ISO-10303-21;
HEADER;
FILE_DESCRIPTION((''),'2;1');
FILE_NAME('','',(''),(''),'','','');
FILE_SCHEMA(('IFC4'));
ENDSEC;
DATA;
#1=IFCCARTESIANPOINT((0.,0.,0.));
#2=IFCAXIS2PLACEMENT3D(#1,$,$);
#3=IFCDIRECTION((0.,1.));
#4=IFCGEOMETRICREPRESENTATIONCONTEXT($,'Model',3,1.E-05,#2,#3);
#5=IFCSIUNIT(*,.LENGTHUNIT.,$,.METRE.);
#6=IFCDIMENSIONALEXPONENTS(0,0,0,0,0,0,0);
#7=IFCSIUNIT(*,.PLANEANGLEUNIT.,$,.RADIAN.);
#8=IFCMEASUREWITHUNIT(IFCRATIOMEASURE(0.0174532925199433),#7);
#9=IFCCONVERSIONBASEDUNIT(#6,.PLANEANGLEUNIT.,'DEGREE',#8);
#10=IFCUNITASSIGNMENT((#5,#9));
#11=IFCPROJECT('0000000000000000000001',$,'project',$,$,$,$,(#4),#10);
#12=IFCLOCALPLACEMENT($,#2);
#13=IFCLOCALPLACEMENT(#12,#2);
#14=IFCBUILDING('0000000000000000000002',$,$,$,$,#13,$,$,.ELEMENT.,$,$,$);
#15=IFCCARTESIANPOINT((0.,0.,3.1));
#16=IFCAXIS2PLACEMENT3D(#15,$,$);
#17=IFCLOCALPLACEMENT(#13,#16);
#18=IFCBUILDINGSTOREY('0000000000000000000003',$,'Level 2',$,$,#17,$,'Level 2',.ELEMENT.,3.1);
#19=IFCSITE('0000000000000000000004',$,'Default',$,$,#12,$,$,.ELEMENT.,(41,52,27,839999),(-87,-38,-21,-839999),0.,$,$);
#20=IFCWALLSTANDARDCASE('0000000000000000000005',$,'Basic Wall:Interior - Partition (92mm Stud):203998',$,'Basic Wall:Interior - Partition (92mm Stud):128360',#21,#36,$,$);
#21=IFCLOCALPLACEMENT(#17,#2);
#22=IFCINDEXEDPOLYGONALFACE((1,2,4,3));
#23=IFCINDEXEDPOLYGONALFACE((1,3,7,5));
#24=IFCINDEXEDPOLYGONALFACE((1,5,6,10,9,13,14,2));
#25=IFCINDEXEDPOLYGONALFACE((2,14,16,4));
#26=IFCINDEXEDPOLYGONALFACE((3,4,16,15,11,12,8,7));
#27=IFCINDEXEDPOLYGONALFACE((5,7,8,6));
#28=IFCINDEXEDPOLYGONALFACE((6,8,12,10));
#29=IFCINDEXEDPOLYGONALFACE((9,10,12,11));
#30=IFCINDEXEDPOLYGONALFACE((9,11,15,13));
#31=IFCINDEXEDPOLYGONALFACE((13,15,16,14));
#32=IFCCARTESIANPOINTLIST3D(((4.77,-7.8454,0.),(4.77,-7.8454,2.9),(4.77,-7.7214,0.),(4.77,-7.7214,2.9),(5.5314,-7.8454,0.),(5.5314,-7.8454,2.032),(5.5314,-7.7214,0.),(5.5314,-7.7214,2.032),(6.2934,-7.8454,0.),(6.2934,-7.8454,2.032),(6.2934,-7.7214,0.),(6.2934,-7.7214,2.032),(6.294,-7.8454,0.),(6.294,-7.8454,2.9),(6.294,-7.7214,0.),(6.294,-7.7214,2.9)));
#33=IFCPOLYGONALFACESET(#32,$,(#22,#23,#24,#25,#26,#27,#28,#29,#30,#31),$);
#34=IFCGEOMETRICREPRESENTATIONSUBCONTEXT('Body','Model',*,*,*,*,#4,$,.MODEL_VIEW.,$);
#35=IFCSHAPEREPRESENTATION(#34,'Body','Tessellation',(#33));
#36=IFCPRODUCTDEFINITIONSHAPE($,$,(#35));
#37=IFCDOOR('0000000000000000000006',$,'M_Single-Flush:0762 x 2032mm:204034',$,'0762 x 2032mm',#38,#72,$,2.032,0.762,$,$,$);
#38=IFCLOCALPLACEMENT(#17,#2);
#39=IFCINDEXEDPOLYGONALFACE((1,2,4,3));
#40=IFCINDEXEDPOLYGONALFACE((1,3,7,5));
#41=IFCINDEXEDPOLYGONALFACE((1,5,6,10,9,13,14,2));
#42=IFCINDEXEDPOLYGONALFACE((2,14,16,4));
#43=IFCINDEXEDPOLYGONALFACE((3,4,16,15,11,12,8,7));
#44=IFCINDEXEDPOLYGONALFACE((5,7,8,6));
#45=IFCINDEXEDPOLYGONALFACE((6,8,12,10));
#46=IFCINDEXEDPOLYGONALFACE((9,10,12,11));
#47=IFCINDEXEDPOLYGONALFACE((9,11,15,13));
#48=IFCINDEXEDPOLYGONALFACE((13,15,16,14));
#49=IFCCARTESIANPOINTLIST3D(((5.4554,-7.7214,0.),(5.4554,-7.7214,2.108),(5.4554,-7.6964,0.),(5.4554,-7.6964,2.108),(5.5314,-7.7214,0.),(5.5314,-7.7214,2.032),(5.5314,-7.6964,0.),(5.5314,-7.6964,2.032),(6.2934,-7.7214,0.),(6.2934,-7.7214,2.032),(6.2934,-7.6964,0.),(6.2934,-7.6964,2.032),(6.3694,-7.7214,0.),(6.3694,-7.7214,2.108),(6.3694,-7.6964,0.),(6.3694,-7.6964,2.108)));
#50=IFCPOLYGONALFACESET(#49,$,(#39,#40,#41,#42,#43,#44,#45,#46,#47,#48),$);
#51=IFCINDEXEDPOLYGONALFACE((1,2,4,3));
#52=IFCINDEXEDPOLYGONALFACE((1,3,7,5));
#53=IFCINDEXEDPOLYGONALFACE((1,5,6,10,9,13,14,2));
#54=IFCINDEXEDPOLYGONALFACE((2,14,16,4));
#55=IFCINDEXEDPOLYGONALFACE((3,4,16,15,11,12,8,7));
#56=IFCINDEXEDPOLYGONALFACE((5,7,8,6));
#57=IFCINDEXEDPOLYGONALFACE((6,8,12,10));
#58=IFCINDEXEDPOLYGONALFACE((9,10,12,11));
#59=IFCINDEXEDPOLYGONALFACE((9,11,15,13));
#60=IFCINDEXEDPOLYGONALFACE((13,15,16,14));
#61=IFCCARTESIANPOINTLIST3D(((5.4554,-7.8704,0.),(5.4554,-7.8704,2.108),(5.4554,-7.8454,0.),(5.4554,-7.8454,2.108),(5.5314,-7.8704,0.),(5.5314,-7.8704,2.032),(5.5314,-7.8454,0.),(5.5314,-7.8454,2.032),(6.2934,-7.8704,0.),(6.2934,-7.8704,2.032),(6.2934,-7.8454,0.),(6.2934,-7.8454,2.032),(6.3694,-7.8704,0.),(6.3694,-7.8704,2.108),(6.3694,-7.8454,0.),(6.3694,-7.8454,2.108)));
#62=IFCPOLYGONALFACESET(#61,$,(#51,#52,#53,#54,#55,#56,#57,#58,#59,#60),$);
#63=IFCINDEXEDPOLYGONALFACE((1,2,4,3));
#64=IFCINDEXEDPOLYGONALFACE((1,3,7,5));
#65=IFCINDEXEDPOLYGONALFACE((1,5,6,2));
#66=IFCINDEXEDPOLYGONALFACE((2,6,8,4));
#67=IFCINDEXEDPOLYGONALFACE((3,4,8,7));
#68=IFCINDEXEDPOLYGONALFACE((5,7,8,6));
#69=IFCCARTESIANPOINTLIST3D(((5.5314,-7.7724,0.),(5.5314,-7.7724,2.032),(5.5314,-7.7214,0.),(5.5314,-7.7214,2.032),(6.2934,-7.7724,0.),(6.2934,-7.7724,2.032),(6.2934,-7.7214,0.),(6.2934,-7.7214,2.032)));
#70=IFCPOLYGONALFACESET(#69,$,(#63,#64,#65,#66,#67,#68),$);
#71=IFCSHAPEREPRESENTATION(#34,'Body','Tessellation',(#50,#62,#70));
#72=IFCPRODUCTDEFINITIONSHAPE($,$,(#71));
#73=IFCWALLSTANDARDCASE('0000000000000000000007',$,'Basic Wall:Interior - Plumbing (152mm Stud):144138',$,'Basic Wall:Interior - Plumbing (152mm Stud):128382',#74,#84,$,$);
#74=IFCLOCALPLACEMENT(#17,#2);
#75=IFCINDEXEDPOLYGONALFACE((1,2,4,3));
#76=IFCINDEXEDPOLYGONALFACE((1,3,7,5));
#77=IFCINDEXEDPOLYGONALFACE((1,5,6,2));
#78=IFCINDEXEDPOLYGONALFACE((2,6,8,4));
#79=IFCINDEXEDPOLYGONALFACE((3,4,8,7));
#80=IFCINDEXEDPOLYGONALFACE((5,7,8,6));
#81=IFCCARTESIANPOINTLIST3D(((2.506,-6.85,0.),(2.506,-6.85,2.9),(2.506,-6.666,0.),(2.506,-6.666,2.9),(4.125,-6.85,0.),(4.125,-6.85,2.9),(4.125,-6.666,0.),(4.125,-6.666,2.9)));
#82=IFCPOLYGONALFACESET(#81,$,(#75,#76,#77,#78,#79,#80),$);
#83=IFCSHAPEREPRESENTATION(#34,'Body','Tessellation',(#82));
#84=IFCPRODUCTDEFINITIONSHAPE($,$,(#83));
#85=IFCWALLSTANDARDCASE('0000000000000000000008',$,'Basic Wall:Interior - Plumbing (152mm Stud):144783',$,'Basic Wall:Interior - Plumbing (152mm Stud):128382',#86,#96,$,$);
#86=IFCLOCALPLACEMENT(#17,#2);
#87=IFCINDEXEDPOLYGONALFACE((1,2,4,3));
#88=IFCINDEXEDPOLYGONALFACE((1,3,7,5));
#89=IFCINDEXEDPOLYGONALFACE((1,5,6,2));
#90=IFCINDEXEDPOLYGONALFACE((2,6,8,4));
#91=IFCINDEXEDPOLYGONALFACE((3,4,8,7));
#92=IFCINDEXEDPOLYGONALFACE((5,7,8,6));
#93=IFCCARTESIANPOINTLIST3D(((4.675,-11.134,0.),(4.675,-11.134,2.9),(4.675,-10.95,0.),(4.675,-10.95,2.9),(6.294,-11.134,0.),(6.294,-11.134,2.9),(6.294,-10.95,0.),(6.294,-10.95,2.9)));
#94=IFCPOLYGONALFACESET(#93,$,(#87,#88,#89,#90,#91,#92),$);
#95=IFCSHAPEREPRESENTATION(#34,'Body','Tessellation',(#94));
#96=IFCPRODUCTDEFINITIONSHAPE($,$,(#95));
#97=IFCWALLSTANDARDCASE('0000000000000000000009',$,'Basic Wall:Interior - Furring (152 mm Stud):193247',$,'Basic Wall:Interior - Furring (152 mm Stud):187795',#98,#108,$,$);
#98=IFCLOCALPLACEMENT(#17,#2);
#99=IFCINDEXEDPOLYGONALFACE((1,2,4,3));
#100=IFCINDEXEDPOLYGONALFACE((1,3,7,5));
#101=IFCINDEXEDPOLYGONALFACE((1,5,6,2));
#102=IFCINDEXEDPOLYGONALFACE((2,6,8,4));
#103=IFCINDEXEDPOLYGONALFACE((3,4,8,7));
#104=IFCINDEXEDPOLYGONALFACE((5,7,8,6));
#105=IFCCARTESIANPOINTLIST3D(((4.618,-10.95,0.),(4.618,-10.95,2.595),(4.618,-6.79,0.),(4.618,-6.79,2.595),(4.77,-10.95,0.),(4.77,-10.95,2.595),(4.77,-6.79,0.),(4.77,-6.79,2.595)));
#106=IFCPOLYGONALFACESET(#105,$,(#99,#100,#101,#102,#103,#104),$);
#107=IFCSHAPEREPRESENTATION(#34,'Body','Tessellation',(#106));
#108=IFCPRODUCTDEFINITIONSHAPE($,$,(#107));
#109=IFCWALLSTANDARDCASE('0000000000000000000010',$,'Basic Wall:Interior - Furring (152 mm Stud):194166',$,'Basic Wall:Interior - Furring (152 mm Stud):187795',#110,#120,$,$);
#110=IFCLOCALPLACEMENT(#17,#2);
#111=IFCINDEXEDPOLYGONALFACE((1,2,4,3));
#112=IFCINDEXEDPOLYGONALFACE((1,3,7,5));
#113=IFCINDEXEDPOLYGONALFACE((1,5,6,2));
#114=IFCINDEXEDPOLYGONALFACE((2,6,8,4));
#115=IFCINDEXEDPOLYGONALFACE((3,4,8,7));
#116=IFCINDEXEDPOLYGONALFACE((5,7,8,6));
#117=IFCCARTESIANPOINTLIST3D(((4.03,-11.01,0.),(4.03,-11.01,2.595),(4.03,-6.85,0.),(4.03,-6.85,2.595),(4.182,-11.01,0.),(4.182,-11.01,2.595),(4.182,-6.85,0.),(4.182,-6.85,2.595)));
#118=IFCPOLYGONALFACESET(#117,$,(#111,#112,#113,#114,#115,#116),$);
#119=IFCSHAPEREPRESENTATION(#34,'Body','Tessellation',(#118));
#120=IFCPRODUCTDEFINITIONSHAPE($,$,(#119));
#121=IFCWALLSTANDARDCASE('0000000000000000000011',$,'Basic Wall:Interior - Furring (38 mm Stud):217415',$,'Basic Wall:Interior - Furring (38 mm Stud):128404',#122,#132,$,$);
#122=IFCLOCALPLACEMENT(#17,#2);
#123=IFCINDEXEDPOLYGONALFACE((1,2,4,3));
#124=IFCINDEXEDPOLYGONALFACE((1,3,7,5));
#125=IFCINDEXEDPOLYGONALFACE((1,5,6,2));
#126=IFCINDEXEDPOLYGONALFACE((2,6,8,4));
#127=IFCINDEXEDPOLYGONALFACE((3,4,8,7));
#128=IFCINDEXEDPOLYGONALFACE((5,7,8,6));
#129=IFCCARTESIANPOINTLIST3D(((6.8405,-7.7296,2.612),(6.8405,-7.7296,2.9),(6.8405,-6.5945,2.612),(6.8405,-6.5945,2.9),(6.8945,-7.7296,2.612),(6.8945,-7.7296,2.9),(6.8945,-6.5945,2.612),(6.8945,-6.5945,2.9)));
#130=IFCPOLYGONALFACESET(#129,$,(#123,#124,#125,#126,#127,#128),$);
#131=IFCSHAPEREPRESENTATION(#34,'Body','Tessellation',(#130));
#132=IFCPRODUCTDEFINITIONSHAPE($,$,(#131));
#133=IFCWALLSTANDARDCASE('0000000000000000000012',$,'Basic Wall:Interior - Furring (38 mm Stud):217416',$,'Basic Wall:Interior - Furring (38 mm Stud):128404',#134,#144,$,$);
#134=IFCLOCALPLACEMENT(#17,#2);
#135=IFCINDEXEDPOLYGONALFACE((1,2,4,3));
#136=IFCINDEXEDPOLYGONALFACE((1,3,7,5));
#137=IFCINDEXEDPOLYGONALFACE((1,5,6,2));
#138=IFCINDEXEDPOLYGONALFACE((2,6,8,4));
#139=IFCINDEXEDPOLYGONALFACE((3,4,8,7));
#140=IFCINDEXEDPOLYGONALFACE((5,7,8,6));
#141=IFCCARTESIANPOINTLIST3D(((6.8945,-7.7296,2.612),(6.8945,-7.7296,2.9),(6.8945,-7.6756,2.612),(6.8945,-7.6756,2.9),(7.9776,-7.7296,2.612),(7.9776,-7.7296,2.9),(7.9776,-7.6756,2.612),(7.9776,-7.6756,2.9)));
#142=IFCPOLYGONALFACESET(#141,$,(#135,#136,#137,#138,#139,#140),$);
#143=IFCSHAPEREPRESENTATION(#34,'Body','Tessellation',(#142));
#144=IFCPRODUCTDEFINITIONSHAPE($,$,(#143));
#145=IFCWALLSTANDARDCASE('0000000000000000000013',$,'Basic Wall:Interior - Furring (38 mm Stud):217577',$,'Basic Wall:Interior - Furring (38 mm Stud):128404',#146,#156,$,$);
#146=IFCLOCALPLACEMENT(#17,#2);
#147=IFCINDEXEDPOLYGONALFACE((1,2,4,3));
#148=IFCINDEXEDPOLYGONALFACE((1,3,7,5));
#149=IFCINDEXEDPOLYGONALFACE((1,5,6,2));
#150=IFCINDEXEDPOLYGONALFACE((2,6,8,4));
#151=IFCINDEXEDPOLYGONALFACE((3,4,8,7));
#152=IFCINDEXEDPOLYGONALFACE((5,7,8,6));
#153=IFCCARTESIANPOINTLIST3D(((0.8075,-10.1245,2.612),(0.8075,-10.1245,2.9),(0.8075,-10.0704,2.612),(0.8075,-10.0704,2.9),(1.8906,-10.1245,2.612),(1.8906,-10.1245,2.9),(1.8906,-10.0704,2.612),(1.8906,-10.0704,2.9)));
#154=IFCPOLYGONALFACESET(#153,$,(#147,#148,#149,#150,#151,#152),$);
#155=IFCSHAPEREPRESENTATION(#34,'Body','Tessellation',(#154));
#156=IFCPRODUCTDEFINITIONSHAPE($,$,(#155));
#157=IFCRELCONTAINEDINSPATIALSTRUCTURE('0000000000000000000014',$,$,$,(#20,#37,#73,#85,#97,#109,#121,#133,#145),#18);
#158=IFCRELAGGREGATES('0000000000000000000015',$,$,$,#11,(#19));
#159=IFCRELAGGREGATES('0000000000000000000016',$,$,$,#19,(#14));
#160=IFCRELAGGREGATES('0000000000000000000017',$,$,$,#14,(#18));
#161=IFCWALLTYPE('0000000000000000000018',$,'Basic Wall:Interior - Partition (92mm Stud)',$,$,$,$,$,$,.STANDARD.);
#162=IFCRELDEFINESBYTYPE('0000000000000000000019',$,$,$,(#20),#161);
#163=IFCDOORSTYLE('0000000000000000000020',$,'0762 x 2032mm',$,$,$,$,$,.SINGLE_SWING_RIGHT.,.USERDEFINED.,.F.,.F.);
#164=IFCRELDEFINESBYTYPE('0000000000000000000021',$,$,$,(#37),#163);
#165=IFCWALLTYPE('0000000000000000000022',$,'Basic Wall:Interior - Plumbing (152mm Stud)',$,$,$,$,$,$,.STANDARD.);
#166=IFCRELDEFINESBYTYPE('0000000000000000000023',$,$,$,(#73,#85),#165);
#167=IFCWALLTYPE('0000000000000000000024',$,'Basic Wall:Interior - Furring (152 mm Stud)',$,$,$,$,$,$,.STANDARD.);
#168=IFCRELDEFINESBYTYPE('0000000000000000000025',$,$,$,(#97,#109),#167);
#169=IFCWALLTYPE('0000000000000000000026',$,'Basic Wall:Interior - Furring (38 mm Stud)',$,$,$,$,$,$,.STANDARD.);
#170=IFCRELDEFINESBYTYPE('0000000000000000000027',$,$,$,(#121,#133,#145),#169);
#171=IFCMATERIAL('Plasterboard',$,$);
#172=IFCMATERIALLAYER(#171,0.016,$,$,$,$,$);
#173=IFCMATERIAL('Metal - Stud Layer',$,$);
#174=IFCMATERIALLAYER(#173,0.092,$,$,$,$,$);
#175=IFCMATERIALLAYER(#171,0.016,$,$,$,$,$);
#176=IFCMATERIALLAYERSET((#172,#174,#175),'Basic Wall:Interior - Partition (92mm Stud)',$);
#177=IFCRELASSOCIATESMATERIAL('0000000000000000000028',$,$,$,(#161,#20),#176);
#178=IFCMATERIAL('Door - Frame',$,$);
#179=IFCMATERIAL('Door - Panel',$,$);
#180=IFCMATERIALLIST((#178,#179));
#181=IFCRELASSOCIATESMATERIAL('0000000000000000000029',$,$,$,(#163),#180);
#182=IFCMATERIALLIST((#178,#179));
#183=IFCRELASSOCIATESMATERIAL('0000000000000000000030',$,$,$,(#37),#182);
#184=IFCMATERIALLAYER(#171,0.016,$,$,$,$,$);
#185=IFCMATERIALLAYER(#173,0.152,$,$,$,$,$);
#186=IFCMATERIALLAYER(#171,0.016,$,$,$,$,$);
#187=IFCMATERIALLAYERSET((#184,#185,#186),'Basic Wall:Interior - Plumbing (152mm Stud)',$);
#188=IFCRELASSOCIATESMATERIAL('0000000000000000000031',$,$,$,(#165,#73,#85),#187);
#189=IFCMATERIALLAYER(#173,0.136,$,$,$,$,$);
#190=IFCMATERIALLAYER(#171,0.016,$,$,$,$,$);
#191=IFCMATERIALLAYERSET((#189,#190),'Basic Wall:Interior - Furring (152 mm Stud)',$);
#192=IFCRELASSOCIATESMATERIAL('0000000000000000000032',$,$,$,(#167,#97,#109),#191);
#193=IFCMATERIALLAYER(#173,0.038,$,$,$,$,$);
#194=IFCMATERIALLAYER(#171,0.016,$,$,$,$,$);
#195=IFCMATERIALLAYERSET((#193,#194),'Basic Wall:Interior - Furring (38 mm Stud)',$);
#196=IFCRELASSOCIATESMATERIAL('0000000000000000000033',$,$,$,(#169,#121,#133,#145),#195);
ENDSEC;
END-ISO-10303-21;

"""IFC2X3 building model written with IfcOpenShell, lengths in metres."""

from ifc_helpers import new_model, entity, si_unit, converted_unit, direction, frame, frame_2d, origin, origin_2d_with_axis, place, context, subcontext, project, spatial, polyline, rectangle, outline, extrude, source, transform, mapped, material, material_list, layer, layer_set, layer_usage, type_object, type_shapes, element, fill, save


model = new_model("IFC2X3")

# Units and contexts
model_context = context("Model", 3, precision=1e-05, world=origin(), true_north=direction((0.0, 1.0)))
body_context = subcontext(model_context, "Body", "Model", "MODEL_VIEW")
ifc_project = project(units=[si_unit("LENGTHUNIT", "METRE"), converted_unit("PLANEANGLEUNIT", "DEGREE", entity("IfcRatioMeasure", 0.0174532925199433), si_unit("PLANEANGLEUNIT", "RADIAN"), dimensions=[0, 0, 0, 0, 0, 0, 0])], contexts=[model_context])

# Site, building, storey
site_placement = place(None, origin())
site = spatial("IfcSite", under=ifc_project, at=site_placement, Name="Default", CompositionType="ELEMENT", RefLatitude=(41, 52, 27, 839999), RefLongitude=(-87, -38, -21, -839999), RefElevation=0.0)
building_placement = place(site_placement, origin())
building = spatial("IfcBuilding", under=site, at=building_placement, CompositionType="ELEMENT")
storey_placement = place(building_placement, frame((0.0, 0.0, 3.1)))
storey = spatial("IfcBuildingStorey", under=building, at=storey_placement, Name="Level 2", LongName="Level 2", CompositionType="ELEMENT", Elevation=3.1)

# Shared definitions
ifc_material_1 = material(Name="Plasterboard")
ifc_layer_1 = layer(ifc_material_1, 0.016)
ifc_material_2 = material(Name="Metal - Stud Layer")
ifc_layer_2 = layer(ifc_material_2, 0.092)
ifc_layer_3 = layer(ifc_material_1, 0.016)
ifc_layer_set_1 = layer_set([ifc_layer_1, ifc_layer_2, ifc_layer_3], Name="Basic Wall:Interior - Partition (92mm Stud)")
wall_type_1 = type_object("IfcWallType", Name="Basic Wall:Interior - Partition (92mm Stud)", PredefinedType="STANDARD", material=ifc_layer_set_1)

# Wall, opening, door
ifc_material_3 = material(Name="Door - Frame")
ifc_material_4 = material(Name="Door - Panel")
ifc_material_list_1 = material_list([ifc_material_3, ifc_material_4])
door_style = type_object("IfcDoorStyle", Name="0762 x 2032mm", ConstructionType="USERDEFINED", OperationType="SINGLE_SWING_RIGHT", ParameterTakesPrecedence=False, Sizeable=False, material=ifc_material_list_1)
shared_shape_1 = source(origin(), body_context, "Body", "SweptSolid", [
    extrude(outline(polyline([(-0.457, -1.073), (0.457, -1.073), (0.457, 1.035), (0.381, 1.035), (0.381, -0.997), (-0.381, -0.997), (-0.381, 1.035), (-0.457, 1.035), (-0.457, -1.073)])), frame((0.381, 0.124, 1.035), z_axis=(0.0, 1.0, 0.0), x_axis=(1.0, 0.0, 0.0)), (0.0, 0.0, 1.0), 0.025),
    extrude(outline(polyline([(-1.073, -0.457), (1.035, -0.457), (1.035, -0.381), (-0.997, -0.381), (-0.997, 0.381), (1.035, 0.381), (1.035, 0.457), (-1.073, 0.457), (-1.073, -0.457)])), frame((0.381, -0.025, 1.035), z_axis=(0.0, 1.0, 0.0), x_axis=(0.0, 0.0, -1.0)), (0.0, 0.0, 1.0), 0.025),
    extrude(rectangle(XDim=0.051, YDim=0.762, at=origin_2d_with_axis()), frame((0.381, 0.0985, 0.0), z_axis=(0.0, 0.0, 1.0), x_axis=(0.0, 1.0, 0.0)), (0.0, 0.0, 1.0), 2.032),
])
type_shapes(door_style, [shared_shape_1])
ifc_layer_usage_1 = layer_usage(ifc_layer_set_1, "AXIS2", "POSITIVE", -0.062)
wall_1_placement = place(storey_placement, frame((4.77, -7.7834, 0.0)))
wall_1 = element("IfcWallStandardCase", 1, at=wall_1_placement, inside=storey, type_object=wall_type_1, material=ifc_layer_usage_1, Name="Basic Wall:Interior - Partition (92mm Stud):203998", ObjectType="Basic Wall:Interior - Partition (92mm Stud):128360", context=body_context, shape_type="SweptSolid", body=[
    extrude(rectangle(XDim=1.524, YDim=0.124, at=frame_2d((0.762, 0.0), x_axis=(-1.0, 0.0))), origin(), (0.0, 0.0, 1.0), 2.9),
])
opening_1_placement = place(wall_1_placement, frame((0.7614, -0.062, 0.0)))
opening_1 = element("IfcOpeningElement", 2, at=opening_1_placement, cuts=wall_1, ObjectType="Opening", context=body_context, shape_type="SweptSolid", body=[
    extrude(rectangle(XDim=0.762, YDim=2.032, at=frame_2d((1.016, 0.381), x_axis=(0.0, 1.0))), frame((0.0, 0.0, 0.0), z_axis=(0.0, 1.0, 0.0), x_axis=(0.0, 0.0, 1.0)), (0.0, 0.0, 1.0), 0.124),
])
ifc_material_list_2 = material_list([ifc_material_3, ifc_material_4])
door_1_placement = place(opening_1_placement, origin())
door_1 = element("IfcDoor", 3, at=door_1_placement, inside=storey, type_object=door_style, material=ifc_material_list_2, Name="M_Single-Flush:0762 x 2032mm:204034", ObjectType="0762 x 2032mm", OverallHeight=2.032, OverallWidth=0.762, context=body_context, shape_type="MappedRepresentation", body=[
    mapped(shared_shape_1, transform((0.0, 0.0, 0.0), scale=1.0)),
])
fill(opening_1, door_1)

# Walls
ifc_layer_4 = layer(ifc_material_1, 0.016)
ifc_layer_5 = layer(ifc_material_2, 0.152)
ifc_layer_6 = layer(ifc_material_1, 0.016)
ifc_layer_set_2 = layer_set([ifc_layer_4, ifc_layer_5, ifc_layer_6], Name="Basic Wall:Interior - Plumbing (152mm Stud)")
ifc_layer_usage_2 = layer_usage(ifc_layer_set_2, "AXIS2", "NEGATIVE", 0.092)
wall_type_2 = type_object("IfcWallType", Name="Basic Wall:Interior - Plumbing (152mm Stud)", PredefinedType="STANDARD", material=ifc_layer_set_2)
wall_2_placement = place(storey_placement, frame((2.506, -6.758, 0.0)))
element("IfcWallStandardCase", 4, at=wall_2_placement, inside=storey, type_object=wall_type_2, material=ifc_layer_usage_2, Name="Basic Wall:Interior - Plumbing (152mm Stud):144138", ObjectType="Basic Wall:Interior - Plumbing (152mm Stud):128382", context=body_context, shape_type="SweptSolid", body=[
    extrude(rectangle(XDim=1.619, YDim=0.184, at=frame_2d((0.8095, 0.0), x_axis=(-1.0, 0.0))), origin(), (0.0, 0.0, 1.0), 2.9),
])
ifc_layer_usage_3 = layer_usage(ifc_layer_set_2, "AXIS2", "NEGATIVE", 0.092)
wall_3_placement = place(storey_placement, frame((6.294, -11.042, 0.0), z_axis=(0.0, 0.0, 1.0), x_axis=(-1.0, 0.0, 0.0)))
element("IfcWallStandardCase", 5, at=wall_3_placement, inside=storey, type_object=wall_type_2, material=ifc_layer_usage_3, Name="Basic Wall:Interior - Plumbing (152mm Stud):144783", ObjectType="Basic Wall:Interior - Plumbing (152mm Stud):128382", context=body_context, shape_type="SweptSolid", body=[
    extrude(rectangle(XDim=1.619, YDim=0.184, at=frame_2d((0.8095, 0.0), x_axis=(-1.0, 0.0))), origin(), (0.0, 0.0, 1.0), 2.9),
])
ifc_layer_7 = layer(ifc_material_2, 0.136)
ifc_layer_8 = layer(ifc_material_1, 0.016)
ifc_layer_set_3 = layer_set([ifc_layer_7, ifc_layer_8], Name="Basic Wall:Interior - Furring (152 mm Stud)")
ifc_layer_usage_4 = layer_usage(ifc_layer_set_3, "AXIS2", "POSITIVE", -0.076)
wall_type_3 = type_object("IfcWallType", Name="Basic Wall:Interior - Furring (152 mm Stud)", PredefinedType="STANDARD", material=ifc_layer_set_3)
wall_4_placement = place(storey_placement, frame((4.694, -6.79, 0.0), z_axis=(0.0, 0.0, 1.0), x_axis=(0.0, -1.0, 0.0)))
element("IfcWallStandardCase", 6, at=wall_4_placement, inside=storey, type_object=wall_type_3, material=ifc_layer_usage_4, Name="Basic Wall:Interior - Furring (152 mm Stud):193247", ObjectType="Basic Wall:Interior - Furring (152 mm Stud):187795", context=body_context, shape_type="SweptSolid", body=[
    extrude(rectangle(XDim=4.16, YDim=0.152, at=frame_2d((2.08, 0.0), x_axis=(-1.0, 0.0))), origin(), (0.0, 0.0, 1.0), 2.595),
])
ifc_layer_usage_5 = layer_usage(ifc_layer_set_3, "AXIS2", "POSITIVE", -0.076)
wall_5_placement = place(storey_placement, frame((4.106, -11.01, 0.0), z_axis=(0.0, 0.0, 1.0), x_axis=(0.0, 1.0, 0.0)))
element("IfcWallStandardCase", 7, at=wall_5_placement, inside=storey, type_object=wall_type_3, material=ifc_layer_usage_5, Name="Basic Wall:Interior - Furring (152 mm Stud):194166", ObjectType="Basic Wall:Interior - Furring (152 mm Stud):187795", context=body_context, shape_type="SweptSolid", body=[
    extrude(rectangle(XDim=4.16, YDim=0.152, at=frame_2d((2.08, 0.0), x_axis=(-1.0, 0.0))), origin(), (0.0, 0.0, 1.0), 2.595),
])
ifc_layer_9 = layer(ifc_material_2, 0.038)
ifc_layer_10 = layer(ifc_material_1, 0.016)
ifc_layer_set_4 = layer_set([ifc_layer_9, ifc_layer_10], Name="Basic Wall:Interior - Furring (38 mm Stud)")
ifc_layer_usage_6 = layer_usage(ifc_layer_set_4, "AXIS2", "NEGATIVE", 0.027)
wall_type_4 = type_object("IfcWallType", Name="Basic Wall:Interior - Furring (38 mm Stud)", PredefinedType="STANDARD", material=ifc_layer_set_4)
wall_6_placement = place(storey_placement, frame((6.8675, -7.7296, 2.612), z_axis=(0.0, 0.0, 1.0), x_axis=(0.0, 1.0, 0.0)))
element("IfcWallStandardCase", 8, at=wall_6_placement, inside=storey, type_object=wall_type_4, material=ifc_layer_usage_6, Name="Basic Wall:Interior - Furring (38 mm Stud):217415", ObjectType="Basic Wall:Interior - Furring (38 mm Stud):128404", context=body_context, shape_type="SweptSolid", body=[
    extrude(rectangle(XDim=1.1351, YDim=0.054, at=frame_2d((0.5675, 0.0), x_axis=(-1.0, 0.0))), origin(), (0.0, 0.0, 1.0), 0.288),
])
ifc_layer_usage_7 = layer_usage(ifc_layer_set_4, "AXIS2", "NEGATIVE", 0.027)
wall_7_placement = place(storey_placement, frame((7.9776, -7.7026, 2.612), z_axis=(0.0, 0.0, 1.0), x_axis=(-1.0, 0.0, 0.0)))
element("IfcWallStandardCase", 9, at=wall_7_placement, inside=storey, type_object=wall_type_4, material=ifc_layer_usage_7, Name="Basic Wall:Interior - Furring (38 mm Stud):217416", ObjectType="Basic Wall:Interior - Furring (38 mm Stud):128404", context=body_context, shape_type="SweptSolid", body=[
    extrude(rectangle(XDim=1.0831, YDim=0.054, at=frame_2d((0.5415, 0.0), x_axis=(-1.0, 0.0))), origin(), (0.0, 0.0, 1.0), 0.288),
])
ifc_layer_usage_8 = layer_usage(ifc_layer_set_4, "AXIS2", "NEGATIVE", 0.027)
wall_8_placement = place(storey_placement, frame((0.8075, -10.0975, 2.612)))
element("IfcWallStandardCase", 10, at=wall_8_placement, inside=storey, type_object=wall_type_4, material=ifc_layer_usage_8, Name="Basic Wall:Interior - Furring (38 mm Stud):217577", ObjectType="Basic Wall:Interior - Furring (38 mm Stud):128404", context=body_context, shape_type="SweptSolid", body=[
    extrude(rectangle(XDim=1.0831, YDim=0.054, at=frame_2d((0.5415, 0.0), x_axis=(-1.0, 0.0))), origin(), (0.0, 0.0, 1.0), 0.288),
])

save(model, "model.ifc")
